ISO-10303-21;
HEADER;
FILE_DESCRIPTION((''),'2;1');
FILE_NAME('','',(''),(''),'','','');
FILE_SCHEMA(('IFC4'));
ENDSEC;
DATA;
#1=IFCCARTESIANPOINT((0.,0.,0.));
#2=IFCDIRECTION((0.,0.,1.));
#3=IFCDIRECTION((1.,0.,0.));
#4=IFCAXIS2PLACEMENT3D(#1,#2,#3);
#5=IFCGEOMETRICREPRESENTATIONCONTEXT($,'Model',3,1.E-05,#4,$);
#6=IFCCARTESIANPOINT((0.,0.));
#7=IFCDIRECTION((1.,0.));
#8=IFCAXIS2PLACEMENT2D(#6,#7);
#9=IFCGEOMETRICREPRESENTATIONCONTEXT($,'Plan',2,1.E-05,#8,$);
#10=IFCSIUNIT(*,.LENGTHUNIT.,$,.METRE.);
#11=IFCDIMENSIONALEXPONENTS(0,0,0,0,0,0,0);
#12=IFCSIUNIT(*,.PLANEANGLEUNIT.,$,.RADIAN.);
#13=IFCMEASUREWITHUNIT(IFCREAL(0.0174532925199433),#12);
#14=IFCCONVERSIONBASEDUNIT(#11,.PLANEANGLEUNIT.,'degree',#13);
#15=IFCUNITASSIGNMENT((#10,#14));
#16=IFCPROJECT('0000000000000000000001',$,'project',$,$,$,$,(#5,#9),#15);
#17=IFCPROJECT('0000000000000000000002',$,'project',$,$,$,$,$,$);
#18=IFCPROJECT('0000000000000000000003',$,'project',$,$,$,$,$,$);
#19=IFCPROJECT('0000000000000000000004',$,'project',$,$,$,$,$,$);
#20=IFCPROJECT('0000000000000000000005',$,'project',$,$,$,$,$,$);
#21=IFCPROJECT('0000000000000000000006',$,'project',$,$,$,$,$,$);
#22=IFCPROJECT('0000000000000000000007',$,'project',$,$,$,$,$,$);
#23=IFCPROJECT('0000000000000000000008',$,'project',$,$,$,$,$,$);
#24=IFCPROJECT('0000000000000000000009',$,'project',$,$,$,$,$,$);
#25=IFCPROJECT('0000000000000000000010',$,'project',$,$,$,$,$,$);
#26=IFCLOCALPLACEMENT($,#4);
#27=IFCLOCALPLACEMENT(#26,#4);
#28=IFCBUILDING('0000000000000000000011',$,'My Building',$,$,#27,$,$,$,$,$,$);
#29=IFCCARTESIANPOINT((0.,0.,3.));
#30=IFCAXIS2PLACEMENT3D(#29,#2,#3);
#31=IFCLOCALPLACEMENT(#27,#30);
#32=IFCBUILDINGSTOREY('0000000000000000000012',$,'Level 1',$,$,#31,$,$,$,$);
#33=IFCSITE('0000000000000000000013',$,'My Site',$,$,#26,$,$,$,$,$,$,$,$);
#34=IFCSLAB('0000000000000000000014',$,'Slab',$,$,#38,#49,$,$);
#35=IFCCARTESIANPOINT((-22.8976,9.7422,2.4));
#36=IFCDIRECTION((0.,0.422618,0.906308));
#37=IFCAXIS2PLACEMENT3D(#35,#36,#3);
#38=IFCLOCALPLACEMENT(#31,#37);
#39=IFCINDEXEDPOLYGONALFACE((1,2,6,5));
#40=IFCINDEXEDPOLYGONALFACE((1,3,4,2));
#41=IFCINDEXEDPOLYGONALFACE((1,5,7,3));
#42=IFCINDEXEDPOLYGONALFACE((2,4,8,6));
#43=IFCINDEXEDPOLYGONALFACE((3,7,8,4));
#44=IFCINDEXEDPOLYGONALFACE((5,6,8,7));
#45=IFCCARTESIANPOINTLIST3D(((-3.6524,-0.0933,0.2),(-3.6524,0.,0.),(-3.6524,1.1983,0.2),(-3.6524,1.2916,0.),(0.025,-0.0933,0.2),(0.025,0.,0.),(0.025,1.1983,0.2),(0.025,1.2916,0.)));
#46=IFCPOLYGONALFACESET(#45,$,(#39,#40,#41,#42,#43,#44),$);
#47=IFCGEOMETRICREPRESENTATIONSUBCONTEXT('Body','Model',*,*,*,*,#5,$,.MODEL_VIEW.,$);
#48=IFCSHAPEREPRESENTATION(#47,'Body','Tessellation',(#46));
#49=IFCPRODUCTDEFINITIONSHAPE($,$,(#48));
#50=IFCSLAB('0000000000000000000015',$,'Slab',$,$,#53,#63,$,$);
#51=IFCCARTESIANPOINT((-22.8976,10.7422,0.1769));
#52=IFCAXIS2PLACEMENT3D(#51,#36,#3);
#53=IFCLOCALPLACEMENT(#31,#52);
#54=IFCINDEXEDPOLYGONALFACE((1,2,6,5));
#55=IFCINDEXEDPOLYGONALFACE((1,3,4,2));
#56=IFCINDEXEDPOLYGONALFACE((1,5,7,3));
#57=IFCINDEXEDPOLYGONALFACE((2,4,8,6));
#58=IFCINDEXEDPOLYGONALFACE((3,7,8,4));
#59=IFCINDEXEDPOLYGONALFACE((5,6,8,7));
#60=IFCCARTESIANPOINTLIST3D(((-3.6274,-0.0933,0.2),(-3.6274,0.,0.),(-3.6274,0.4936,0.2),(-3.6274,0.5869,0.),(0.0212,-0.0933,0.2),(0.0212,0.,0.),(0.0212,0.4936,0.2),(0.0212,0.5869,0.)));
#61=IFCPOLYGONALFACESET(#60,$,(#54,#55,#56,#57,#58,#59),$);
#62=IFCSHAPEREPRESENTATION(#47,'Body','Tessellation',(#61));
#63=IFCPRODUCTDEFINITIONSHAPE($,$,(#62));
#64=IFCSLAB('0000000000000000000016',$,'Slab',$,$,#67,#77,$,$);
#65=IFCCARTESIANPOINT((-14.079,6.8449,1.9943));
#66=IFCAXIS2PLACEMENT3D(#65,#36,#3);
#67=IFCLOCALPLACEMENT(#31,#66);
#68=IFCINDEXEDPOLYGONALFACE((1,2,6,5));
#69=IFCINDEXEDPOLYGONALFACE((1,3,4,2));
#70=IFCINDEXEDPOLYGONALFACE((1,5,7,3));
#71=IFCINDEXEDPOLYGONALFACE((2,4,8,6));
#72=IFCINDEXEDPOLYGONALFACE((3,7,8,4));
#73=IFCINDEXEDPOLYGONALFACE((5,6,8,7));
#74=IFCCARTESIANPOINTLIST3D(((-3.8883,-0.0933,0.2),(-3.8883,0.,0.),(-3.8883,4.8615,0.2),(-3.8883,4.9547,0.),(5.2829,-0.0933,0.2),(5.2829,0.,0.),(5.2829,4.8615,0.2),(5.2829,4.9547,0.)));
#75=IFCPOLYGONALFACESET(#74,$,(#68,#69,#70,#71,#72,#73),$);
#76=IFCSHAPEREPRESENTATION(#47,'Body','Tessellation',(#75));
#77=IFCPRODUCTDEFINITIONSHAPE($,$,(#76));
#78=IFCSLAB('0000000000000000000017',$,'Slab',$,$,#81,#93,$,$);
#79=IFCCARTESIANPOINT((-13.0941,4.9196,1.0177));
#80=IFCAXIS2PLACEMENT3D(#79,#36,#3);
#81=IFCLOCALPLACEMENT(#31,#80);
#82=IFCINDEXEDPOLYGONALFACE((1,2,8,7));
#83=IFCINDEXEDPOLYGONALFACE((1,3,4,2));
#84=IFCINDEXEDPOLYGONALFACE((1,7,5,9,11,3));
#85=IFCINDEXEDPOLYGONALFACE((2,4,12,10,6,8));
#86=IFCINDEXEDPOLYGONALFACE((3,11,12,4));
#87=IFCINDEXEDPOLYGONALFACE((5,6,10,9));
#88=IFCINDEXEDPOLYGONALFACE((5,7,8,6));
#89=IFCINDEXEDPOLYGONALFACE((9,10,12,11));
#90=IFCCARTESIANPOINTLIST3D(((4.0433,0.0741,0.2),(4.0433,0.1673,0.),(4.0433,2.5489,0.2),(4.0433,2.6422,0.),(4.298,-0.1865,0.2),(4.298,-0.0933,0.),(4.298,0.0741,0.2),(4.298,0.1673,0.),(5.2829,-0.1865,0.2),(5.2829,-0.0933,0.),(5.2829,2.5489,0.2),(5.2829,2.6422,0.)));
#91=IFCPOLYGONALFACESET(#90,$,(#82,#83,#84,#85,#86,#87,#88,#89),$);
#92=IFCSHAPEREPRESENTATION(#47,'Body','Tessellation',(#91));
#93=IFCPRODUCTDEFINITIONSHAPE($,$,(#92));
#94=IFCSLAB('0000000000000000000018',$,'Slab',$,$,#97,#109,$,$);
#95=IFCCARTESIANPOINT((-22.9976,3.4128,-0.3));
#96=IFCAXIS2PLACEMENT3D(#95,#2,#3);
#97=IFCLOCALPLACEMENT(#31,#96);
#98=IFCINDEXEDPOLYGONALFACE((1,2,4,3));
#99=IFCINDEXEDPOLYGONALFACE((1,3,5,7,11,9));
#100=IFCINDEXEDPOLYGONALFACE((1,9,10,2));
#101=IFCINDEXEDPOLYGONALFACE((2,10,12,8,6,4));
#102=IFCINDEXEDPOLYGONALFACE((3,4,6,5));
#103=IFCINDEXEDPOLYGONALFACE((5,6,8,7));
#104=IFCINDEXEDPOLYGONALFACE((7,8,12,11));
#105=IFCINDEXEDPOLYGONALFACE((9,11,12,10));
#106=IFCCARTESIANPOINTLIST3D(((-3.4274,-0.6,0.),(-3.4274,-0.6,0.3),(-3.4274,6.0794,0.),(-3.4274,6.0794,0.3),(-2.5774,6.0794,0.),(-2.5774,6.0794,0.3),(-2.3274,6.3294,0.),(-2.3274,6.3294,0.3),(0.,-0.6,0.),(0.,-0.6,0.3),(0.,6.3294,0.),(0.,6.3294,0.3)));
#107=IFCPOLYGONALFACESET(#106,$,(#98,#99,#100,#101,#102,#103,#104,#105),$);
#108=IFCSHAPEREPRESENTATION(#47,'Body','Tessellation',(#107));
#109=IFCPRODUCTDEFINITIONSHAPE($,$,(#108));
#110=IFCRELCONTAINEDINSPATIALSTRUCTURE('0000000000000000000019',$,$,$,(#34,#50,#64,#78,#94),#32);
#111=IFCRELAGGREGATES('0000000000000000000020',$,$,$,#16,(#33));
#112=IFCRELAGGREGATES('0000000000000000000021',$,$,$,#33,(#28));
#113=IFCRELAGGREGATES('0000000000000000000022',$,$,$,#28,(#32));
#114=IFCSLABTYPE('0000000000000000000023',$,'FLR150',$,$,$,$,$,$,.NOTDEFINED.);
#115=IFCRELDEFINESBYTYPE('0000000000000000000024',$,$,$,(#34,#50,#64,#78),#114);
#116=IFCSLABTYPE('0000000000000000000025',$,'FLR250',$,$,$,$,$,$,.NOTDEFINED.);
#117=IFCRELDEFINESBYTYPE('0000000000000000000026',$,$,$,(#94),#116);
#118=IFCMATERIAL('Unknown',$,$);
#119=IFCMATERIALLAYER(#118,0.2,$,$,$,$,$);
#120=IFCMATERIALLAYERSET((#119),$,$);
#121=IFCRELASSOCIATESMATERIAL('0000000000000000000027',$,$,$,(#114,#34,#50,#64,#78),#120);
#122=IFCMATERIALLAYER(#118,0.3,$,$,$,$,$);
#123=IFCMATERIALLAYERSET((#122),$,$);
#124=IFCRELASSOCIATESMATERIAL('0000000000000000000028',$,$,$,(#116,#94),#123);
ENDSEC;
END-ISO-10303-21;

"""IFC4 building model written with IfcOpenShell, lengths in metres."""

from ifc_helpers import new_model, entity, si_unit, converted_unit, frame, origin_with_axes, origin_2d_with_axis, place, context, subcontext, project, spatial, line, indexed_curve, outline, extrude, material, layer, layer_set, layer_usage, type_object, element, save


model = new_model("IFC4")

# Units and contexts
model_context = context("Model", 3, precision=1e-05, world=origin_with_axes())
plan_context = context("Plan", 2, precision=1e-05, world=origin_2d_with_axis())
body_context_1 = subcontext(model_context, "Body", "Model", "MODEL_VIEW")
ifc_project_1 = project(units=[si_unit("LENGTHUNIT", "METRE"), converted_unit("PLANEANGLEUNIT", "degree", entity("IfcReal", 0.0174532925199433), si_unit("PLANEANGLEUNIT", "RADIAN"), dimensions=[0, 0, 0, 0, 0, 0, 0])], contexts=[model_context, plan_context])
ifc_project_2 = project()
ifc_project_3 = project()
ifc_project_4 = project()
ifc_project_5 = project()
ifc_project_6 = project()
ifc_project_7 = project()
ifc_project_8 = project()
ifc_project_9 = project()
ifc_project_10 = project()

# Site, building, storey
site_placement = place(None, origin_with_axes())
site = spatial("IfcSite", under=ifc_project_1, at=site_placement, Name="My Site")
building_placement = place(site_placement, origin_with_axes())
building = spatial("IfcBuilding", under=site, at=building_placement, Name="My Building")
storey_placement = place(building_placement, frame((0.0, 0.0, 3.0), z_axis=(0.0, 0.0, 1.0), x_axis=(1.0, 0.0, 0.0)))
storey = spatial("IfcBuildingStorey", under=building, at=storey_placement, Name="Level 1")

# Slabs
ifc_material = material(Name="Unknown")
ifc_layer_1 = layer(ifc_material, 0.2)
ifc_layer_set_1 = layer_set([ifc_layer_1])
ifc_layer_usage_1 = layer_usage(ifc_layer_set_1, "AXIS3", "POSITIVE", 0.0)
slab_type_1 = type_object("IfcSlabType", Name="FLR150", PredefinedType="NOTDEFINED", material=ifc_layer_set_1)
slab_1_placement = place(storey_placement, frame((-22.8976, 9.7422, 2.4), z_axis=(0.0, 0.422618, 0.906308), x_axis=(1.0, 0.0, 0.0)))
element("IfcSlab", 1, at=slab_1_placement, inside=storey, type_object=slab_type_1, material=ifc_layer_usage_1, Name="Slab", context=body_context_1, shape_type="SweptSolid", body=[
    extrude(outline(indexed_curve([(-3.6524, 0.0), (0.025, 0.0), (0.025, 1.2916), (-3.6524, 1.2916)], segments=[line(3, 2), line(2, 1), line(1, 4), line(4, 3)], self_intersect=False)), None, (0.0, -0.422618, 0.906308), 0.2207),
])
ifc_layer_usage_2 = layer_usage(ifc_layer_set_1, "AXIS3", "POSITIVE", 0.0)
slab_2_placement = place(storey_placement, frame((-22.8976, 10.7422, 0.1769), z_axis=(0.0, 0.422618, 0.906308), x_axis=(1.0, 0.0, 0.0)))
element("IfcSlab", 2, at=slab_2_placement, inside=storey, type_object=slab_type_1, material=ifc_layer_usage_2, Name="Slab", context=body_context_1, shape_type="SweptSolid", body=[
    extrude(outline(indexed_curve([(-3.6274, 0.0), (0.0212, 0.0), (0.0212, 0.5869), (-3.6274, 0.5869)], segments=[line(3, 2), line(2, 1), line(1, 4), line(4, 3)], self_intersect=False)), None, (0.0, -0.422618, 0.906308), 0.2207),
])
ifc_layer_usage_3 = layer_usage(ifc_layer_set_1, "AXIS3", "POSITIVE", 0.0)
slab_3_placement = place(storey_placement, frame((-14.079, 6.8449, 1.9943), z_axis=(0.0, 0.422618, 0.906308), x_axis=(1.0, 0.0, 0.0)))
element("IfcSlab", 3, at=slab_3_placement, inside=storey, type_object=slab_type_1, material=ifc_layer_usage_3, Name="Slab", context=body_context_1, shape_type="SweptSolid", body=[
    extrude(outline(indexed_curve([(-3.8883, 0.0), (5.2829, 0.0), (5.2829, 4.9547), (-3.8883, 4.9547)], segments=[line(3, 2), line(2, 1), line(1, 4), line(4, 3)], self_intersect=False)), None, (0.0, -0.422618, 0.906308), 0.2207),
])
ifc_layer_usage_4 = layer_usage(ifc_layer_set_1, "AXIS3", "POSITIVE", 0.0)
slab_4_placement = place(storey_placement, frame((-13.0941, 4.9196, 1.0177), z_axis=(0.0, 0.422618, 0.906308), x_axis=(1.0, 0.0, 0.0)))
element("IfcSlab", 4, at=slab_4_placement, inside=storey, type_object=slab_type_1, material=ifc_layer_usage_4, Name="Slab", context=body_context_1, shape_type="SweptSolid", body=[
    extrude(outline(indexed_curve([(4.0433, 0.1673), (4.0433, 2.6422), (5.2829, 2.6422), (5.2829, -0.0933), (4.298, -0.0933), (4.298, 0.1673)], segments=[line(6, 5), line(5, 4), line(4, 3), line(3, 2), line(2, 1), line(1, 6)], self_intersect=False)), None, (0.0, -0.422618, 0.906308), 0.2207),
])
ifc_layer_2 = layer(ifc_material, 0.3)
ifc_layer_set_2 = layer_set([ifc_layer_2])
ifc_layer_usage_5 = layer_usage(ifc_layer_set_2, "AXIS3", "POSITIVE", 0.0)
slab_type_2 = type_object("IfcSlabType", Name="FLR250", PredefinedType="NOTDEFINED", material=ifc_layer_set_2)
slab_5_placement = place(storey_placement, frame((-22.9976, 3.4128, -0.3), z_axis=(0.0, 0.0, 1.0), x_axis=(1.0, 0.0, 0.0)))
element("IfcSlab", 5, at=slab_5_placement, inside=storey, type_object=slab_type_2, material=ifc_layer_usage_5, Name="Slab", context=body_context_1, shape_type="SweptSolid", body=[
    extrude(outline(indexed_curve([(0.0, 6.3294), (-2.3274, 6.3294), (-2.5774, 6.0794), (-3.4274, 6.0794), (-3.4274, -0.6), (0.0, -0.6)], segments=[line(6, 5), line(5, 4), line(4, 3), line(3, 2), line(2, 1), line(1, 6)], self_intersect=False)), None, (0.0, 0.0, 1.0), 0.3),
])

save(model, "model.ifc")
